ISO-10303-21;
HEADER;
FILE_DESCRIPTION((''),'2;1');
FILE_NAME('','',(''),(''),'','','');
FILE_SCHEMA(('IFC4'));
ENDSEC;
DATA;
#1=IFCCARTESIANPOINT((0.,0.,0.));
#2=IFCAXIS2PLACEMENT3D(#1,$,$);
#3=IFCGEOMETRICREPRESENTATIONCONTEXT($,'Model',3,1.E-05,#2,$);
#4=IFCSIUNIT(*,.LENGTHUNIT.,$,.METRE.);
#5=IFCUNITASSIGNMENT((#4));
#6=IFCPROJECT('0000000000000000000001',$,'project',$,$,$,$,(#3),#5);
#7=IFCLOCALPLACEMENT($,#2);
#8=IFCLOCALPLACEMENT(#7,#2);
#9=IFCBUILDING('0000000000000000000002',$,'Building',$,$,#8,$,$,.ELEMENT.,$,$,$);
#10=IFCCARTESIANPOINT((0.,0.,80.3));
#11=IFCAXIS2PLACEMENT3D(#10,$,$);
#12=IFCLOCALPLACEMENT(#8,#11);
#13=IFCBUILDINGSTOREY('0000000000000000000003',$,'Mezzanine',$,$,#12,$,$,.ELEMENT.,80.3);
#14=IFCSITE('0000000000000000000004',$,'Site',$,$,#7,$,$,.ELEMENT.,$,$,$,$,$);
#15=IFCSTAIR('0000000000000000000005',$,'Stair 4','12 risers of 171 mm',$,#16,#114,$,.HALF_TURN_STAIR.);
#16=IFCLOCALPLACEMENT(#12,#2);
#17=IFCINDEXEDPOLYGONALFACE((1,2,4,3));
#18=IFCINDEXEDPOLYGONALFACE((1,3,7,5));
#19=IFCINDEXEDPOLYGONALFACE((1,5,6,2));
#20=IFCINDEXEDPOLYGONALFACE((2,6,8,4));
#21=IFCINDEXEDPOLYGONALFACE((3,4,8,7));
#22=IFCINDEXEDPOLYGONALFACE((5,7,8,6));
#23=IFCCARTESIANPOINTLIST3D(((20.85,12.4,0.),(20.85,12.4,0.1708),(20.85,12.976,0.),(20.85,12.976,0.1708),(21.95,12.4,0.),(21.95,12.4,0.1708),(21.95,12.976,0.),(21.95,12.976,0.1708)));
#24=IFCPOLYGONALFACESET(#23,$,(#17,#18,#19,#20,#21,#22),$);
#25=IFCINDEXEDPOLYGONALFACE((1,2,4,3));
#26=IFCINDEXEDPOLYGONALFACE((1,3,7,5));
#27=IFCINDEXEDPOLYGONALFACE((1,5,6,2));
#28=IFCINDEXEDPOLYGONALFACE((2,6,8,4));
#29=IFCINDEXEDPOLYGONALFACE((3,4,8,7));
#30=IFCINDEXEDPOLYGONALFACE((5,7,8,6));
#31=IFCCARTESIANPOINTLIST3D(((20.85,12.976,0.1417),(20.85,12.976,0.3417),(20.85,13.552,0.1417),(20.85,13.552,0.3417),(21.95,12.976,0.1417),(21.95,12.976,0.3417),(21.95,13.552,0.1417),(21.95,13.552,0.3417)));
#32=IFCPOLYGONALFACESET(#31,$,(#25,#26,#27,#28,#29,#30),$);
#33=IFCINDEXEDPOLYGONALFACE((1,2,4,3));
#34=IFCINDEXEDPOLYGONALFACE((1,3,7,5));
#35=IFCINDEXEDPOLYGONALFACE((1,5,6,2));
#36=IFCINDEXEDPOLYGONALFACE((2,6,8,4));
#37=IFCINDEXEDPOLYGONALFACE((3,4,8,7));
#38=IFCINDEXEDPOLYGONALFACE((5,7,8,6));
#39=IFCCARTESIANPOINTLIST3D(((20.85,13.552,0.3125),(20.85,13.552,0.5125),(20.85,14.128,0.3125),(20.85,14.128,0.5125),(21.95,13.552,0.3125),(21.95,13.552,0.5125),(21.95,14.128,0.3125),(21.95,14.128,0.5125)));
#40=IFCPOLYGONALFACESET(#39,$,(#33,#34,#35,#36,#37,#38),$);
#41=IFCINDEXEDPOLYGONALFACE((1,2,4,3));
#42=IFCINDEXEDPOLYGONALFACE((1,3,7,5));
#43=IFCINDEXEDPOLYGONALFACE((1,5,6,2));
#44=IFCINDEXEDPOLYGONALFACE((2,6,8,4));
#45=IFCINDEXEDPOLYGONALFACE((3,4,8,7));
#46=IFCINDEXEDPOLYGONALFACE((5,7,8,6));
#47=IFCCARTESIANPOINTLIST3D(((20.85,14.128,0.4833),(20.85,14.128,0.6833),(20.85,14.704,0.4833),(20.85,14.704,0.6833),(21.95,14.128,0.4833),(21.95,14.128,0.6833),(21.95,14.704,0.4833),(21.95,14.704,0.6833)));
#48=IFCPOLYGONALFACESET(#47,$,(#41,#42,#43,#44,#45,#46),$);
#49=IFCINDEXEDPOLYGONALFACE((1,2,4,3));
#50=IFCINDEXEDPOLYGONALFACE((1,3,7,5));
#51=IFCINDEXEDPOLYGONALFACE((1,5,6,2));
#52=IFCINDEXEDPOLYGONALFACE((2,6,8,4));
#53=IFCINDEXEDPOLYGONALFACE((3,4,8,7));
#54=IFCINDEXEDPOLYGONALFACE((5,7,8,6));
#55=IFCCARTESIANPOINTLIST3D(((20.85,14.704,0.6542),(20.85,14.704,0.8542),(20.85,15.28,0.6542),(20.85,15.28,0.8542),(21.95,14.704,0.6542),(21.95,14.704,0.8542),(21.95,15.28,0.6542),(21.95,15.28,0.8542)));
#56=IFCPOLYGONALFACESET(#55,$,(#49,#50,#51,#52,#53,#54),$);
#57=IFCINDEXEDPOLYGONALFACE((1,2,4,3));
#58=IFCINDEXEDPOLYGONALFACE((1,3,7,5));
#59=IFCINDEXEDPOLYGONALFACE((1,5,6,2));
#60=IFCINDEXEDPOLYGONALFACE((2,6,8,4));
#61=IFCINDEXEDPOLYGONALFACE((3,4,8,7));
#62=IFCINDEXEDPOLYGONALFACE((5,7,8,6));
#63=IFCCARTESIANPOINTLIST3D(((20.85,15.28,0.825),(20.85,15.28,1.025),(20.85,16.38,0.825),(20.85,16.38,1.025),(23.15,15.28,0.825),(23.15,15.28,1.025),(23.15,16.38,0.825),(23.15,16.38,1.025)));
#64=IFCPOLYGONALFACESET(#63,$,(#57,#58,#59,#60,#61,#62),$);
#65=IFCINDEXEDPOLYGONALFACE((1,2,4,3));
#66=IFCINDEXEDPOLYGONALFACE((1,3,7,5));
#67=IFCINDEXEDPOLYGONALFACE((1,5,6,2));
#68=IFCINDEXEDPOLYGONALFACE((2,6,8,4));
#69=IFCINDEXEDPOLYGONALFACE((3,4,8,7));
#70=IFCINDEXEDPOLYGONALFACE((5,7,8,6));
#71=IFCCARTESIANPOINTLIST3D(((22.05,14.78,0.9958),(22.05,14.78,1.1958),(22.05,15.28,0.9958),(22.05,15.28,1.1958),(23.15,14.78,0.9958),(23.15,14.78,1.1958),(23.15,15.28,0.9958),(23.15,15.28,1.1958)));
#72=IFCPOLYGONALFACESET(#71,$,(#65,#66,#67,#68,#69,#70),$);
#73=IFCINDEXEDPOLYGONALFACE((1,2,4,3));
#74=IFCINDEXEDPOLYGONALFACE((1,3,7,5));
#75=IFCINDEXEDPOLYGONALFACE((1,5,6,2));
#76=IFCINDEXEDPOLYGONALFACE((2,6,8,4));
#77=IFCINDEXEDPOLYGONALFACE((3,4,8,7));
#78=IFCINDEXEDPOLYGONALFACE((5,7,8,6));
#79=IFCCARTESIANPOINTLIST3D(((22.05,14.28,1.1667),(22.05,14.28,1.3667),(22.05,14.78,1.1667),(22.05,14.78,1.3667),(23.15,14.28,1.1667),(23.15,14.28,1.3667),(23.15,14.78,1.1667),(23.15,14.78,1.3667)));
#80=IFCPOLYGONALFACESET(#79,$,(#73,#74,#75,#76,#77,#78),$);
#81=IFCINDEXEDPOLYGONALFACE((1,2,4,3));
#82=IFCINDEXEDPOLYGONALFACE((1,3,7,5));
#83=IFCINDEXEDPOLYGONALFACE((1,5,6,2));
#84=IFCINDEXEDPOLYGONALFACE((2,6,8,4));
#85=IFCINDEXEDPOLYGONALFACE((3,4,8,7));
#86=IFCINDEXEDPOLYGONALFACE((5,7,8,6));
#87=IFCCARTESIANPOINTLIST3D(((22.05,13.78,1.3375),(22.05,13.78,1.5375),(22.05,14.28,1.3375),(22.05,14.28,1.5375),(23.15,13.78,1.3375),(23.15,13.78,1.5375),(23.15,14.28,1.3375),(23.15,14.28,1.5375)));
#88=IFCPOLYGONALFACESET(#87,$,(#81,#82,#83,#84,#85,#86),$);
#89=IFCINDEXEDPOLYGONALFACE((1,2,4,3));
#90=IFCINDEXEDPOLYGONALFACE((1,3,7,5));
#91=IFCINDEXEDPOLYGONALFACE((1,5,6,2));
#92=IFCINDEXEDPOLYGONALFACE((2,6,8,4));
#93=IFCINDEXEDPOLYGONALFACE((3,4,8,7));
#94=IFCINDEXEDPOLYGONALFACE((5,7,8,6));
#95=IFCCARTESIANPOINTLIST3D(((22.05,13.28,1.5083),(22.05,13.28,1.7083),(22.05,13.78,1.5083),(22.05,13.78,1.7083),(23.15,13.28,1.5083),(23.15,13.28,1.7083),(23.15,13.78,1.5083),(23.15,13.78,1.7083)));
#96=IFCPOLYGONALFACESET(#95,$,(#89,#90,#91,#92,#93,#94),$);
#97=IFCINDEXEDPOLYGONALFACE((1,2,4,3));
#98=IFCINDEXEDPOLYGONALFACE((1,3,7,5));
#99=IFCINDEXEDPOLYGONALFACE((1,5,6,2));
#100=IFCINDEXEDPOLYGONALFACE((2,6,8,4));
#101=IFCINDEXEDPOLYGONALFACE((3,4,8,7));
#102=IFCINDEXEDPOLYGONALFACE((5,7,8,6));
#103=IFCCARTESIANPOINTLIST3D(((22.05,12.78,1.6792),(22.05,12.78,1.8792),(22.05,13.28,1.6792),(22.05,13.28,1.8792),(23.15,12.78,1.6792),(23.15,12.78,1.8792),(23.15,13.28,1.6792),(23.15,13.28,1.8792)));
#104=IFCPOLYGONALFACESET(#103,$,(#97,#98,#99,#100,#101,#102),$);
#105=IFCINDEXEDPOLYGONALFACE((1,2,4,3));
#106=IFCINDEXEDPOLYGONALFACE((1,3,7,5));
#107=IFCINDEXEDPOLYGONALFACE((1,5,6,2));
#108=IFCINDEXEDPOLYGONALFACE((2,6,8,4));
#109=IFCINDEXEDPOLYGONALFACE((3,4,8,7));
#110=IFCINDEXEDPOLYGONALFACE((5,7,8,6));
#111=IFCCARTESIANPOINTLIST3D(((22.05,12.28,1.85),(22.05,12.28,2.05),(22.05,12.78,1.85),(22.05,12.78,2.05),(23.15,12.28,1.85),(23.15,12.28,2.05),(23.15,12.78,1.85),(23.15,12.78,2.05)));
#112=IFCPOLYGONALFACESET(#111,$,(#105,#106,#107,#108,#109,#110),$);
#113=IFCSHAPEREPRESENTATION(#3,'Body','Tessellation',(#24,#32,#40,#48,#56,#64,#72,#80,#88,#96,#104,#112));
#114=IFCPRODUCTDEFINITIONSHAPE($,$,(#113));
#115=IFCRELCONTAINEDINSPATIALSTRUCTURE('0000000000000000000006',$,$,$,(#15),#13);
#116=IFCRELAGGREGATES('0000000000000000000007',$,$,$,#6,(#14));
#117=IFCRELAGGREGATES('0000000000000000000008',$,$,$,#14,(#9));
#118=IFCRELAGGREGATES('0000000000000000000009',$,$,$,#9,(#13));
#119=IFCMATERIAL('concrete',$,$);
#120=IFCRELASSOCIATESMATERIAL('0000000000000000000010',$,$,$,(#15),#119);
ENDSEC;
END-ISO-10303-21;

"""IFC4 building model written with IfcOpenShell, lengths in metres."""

from ifc_helpers import new_model, si_unit, frame, origin, place, context, project, spatial, polyline, outline, extrude, material, element, save


model = new_model("IFC4")

# Units and contexts
model_context = context("Model", 3, precision=1e-05, world=origin())
ifc_project = project(units=[si_unit("LENGTHUNIT", "METRE")], contexts=[model_context])

# Site, building, storey
site_placement = place(None, origin())
site = spatial("IfcSite", under=ifc_project, at=site_placement, Name="Site", CompositionType="ELEMENT")
building_placement = place(site_placement, origin())
building = spatial("IfcBuilding", under=site, at=building_placement, Name="Building", CompositionType="ELEMENT")
storey_placement = place(building_placement, frame((0.0, 0.0, 80.3)))
storey = spatial("IfcBuildingStorey", under=building, at=storey_placement, Name="Mezzanine", CompositionType="ELEMENT", Elevation=80.3)

# Shared definitions
ifc_material = material(Name="concrete")

# Stair
stair_1_placement = place(storey_placement, frame((21.4, 12.4, 0.0), z_axis=(0.0, 0.0, 1.0), x_axis=(0.0, 1.0, 0.0)))
element("IfcStair", 1, at=stair_1_placement, inside=storey, material=ifc_material, Name="Stair 4", Description="12 risers of 171 mm", PredefinedType="HALF_TURN_STAIR", context=model_context, shape_type="SweptSolid", body=[
    extrude(outline(polyline([(0.0, -0.55), (0.576, -0.55), (0.576, 0.55), (0.0, 0.55), (0.0, -0.55)])), origin(), (0.0, 0.0, 1.0), 0.1708),
    extrude(outline(polyline([(0.576, -0.55), (1.152, -0.55), (1.152, 0.55), (0.576, 0.55), (0.576, -0.55)])), frame((0.0, 0.0, 0.1417)), (0.0, 0.0, 1.0), 0.2),
    extrude(outline(polyline([(1.152, -0.55), (1.728, -0.55), (1.728, 0.55), (1.152, 0.55), (1.152, -0.55)])), frame((0.0, 0.0, 0.3125)), (0.0, 0.0, 1.0), 0.2),
    extrude(outline(polyline([(1.728, -0.55), (2.304, -0.55), (2.304, 0.55), (1.728, 0.55), (1.728, -0.55)])), frame((0.0, 0.0, 0.4833)), (0.0, 0.0, 1.0), 0.2),
    extrude(outline(polyline([(2.304, -0.55), (2.88, -0.55), (2.88, 0.55), (2.304, 0.55), (2.304, -0.55)])), frame((0.0, 0.0, 0.6542)), (0.0, 0.0, 1.0), 0.2),
    extrude(outline(polyline([(2.88, -1.75), (3.98, -1.75), (3.98, 0.55), (2.88, 0.55), (2.88, -1.75)])), frame((0.0, 0.0, 0.825)), (0.0, 0.0, 1.0), 0.2),
    extrude(outline(polyline([(2.38, -1.75), (2.88, -1.75), (2.88, -0.65), (2.38, -0.65), (2.38, -1.75)])), frame((0.0, 0.0, 0.9958)), (0.0, 0.0, 1.0), 0.2),
    extrude(outline(polyline([(1.88, -1.75), (2.38, -1.75), (2.38, -0.65), (1.88, -0.65), (1.88, -1.75)])), frame((0.0, 0.0, 1.1667)), (0.0, 0.0, 1.0), 0.2),
    extrude(outline(polyline([(1.38, -1.75), (1.88, -1.75), (1.88, -0.65), (1.38, -0.65), (1.38, -1.75)])), frame((0.0, 0.0, 1.3375)), (0.0, 0.0, 1.0), 0.2),
    extrude(outline(polyline([(0.88, -1.75), (1.38, -1.75), (1.38, -0.65), (0.88, -0.65), (0.88, -1.75)])), frame((0.0, 0.0, 1.5083)), (0.0, 0.0, 1.0), 0.2),
    extrude(outline(polyline([(0.38, -1.75), (0.88, -1.75), (0.88, -0.65), (0.38, -0.65), (0.38, -1.75)])), frame((0.0, 0.0, 1.6792)), (0.0, 0.0, 1.0), 0.2),
    extrude(outline(polyline([(-0.12, -1.75), (0.38, -1.75), (0.38, -0.65), (-0.12, -0.65), (-0.12, -1.75)])), frame((0.0, 0.0, 1.85)), (0.0, 0.0, 1.0), 0.2),
])

save(model, "model.ifc")
